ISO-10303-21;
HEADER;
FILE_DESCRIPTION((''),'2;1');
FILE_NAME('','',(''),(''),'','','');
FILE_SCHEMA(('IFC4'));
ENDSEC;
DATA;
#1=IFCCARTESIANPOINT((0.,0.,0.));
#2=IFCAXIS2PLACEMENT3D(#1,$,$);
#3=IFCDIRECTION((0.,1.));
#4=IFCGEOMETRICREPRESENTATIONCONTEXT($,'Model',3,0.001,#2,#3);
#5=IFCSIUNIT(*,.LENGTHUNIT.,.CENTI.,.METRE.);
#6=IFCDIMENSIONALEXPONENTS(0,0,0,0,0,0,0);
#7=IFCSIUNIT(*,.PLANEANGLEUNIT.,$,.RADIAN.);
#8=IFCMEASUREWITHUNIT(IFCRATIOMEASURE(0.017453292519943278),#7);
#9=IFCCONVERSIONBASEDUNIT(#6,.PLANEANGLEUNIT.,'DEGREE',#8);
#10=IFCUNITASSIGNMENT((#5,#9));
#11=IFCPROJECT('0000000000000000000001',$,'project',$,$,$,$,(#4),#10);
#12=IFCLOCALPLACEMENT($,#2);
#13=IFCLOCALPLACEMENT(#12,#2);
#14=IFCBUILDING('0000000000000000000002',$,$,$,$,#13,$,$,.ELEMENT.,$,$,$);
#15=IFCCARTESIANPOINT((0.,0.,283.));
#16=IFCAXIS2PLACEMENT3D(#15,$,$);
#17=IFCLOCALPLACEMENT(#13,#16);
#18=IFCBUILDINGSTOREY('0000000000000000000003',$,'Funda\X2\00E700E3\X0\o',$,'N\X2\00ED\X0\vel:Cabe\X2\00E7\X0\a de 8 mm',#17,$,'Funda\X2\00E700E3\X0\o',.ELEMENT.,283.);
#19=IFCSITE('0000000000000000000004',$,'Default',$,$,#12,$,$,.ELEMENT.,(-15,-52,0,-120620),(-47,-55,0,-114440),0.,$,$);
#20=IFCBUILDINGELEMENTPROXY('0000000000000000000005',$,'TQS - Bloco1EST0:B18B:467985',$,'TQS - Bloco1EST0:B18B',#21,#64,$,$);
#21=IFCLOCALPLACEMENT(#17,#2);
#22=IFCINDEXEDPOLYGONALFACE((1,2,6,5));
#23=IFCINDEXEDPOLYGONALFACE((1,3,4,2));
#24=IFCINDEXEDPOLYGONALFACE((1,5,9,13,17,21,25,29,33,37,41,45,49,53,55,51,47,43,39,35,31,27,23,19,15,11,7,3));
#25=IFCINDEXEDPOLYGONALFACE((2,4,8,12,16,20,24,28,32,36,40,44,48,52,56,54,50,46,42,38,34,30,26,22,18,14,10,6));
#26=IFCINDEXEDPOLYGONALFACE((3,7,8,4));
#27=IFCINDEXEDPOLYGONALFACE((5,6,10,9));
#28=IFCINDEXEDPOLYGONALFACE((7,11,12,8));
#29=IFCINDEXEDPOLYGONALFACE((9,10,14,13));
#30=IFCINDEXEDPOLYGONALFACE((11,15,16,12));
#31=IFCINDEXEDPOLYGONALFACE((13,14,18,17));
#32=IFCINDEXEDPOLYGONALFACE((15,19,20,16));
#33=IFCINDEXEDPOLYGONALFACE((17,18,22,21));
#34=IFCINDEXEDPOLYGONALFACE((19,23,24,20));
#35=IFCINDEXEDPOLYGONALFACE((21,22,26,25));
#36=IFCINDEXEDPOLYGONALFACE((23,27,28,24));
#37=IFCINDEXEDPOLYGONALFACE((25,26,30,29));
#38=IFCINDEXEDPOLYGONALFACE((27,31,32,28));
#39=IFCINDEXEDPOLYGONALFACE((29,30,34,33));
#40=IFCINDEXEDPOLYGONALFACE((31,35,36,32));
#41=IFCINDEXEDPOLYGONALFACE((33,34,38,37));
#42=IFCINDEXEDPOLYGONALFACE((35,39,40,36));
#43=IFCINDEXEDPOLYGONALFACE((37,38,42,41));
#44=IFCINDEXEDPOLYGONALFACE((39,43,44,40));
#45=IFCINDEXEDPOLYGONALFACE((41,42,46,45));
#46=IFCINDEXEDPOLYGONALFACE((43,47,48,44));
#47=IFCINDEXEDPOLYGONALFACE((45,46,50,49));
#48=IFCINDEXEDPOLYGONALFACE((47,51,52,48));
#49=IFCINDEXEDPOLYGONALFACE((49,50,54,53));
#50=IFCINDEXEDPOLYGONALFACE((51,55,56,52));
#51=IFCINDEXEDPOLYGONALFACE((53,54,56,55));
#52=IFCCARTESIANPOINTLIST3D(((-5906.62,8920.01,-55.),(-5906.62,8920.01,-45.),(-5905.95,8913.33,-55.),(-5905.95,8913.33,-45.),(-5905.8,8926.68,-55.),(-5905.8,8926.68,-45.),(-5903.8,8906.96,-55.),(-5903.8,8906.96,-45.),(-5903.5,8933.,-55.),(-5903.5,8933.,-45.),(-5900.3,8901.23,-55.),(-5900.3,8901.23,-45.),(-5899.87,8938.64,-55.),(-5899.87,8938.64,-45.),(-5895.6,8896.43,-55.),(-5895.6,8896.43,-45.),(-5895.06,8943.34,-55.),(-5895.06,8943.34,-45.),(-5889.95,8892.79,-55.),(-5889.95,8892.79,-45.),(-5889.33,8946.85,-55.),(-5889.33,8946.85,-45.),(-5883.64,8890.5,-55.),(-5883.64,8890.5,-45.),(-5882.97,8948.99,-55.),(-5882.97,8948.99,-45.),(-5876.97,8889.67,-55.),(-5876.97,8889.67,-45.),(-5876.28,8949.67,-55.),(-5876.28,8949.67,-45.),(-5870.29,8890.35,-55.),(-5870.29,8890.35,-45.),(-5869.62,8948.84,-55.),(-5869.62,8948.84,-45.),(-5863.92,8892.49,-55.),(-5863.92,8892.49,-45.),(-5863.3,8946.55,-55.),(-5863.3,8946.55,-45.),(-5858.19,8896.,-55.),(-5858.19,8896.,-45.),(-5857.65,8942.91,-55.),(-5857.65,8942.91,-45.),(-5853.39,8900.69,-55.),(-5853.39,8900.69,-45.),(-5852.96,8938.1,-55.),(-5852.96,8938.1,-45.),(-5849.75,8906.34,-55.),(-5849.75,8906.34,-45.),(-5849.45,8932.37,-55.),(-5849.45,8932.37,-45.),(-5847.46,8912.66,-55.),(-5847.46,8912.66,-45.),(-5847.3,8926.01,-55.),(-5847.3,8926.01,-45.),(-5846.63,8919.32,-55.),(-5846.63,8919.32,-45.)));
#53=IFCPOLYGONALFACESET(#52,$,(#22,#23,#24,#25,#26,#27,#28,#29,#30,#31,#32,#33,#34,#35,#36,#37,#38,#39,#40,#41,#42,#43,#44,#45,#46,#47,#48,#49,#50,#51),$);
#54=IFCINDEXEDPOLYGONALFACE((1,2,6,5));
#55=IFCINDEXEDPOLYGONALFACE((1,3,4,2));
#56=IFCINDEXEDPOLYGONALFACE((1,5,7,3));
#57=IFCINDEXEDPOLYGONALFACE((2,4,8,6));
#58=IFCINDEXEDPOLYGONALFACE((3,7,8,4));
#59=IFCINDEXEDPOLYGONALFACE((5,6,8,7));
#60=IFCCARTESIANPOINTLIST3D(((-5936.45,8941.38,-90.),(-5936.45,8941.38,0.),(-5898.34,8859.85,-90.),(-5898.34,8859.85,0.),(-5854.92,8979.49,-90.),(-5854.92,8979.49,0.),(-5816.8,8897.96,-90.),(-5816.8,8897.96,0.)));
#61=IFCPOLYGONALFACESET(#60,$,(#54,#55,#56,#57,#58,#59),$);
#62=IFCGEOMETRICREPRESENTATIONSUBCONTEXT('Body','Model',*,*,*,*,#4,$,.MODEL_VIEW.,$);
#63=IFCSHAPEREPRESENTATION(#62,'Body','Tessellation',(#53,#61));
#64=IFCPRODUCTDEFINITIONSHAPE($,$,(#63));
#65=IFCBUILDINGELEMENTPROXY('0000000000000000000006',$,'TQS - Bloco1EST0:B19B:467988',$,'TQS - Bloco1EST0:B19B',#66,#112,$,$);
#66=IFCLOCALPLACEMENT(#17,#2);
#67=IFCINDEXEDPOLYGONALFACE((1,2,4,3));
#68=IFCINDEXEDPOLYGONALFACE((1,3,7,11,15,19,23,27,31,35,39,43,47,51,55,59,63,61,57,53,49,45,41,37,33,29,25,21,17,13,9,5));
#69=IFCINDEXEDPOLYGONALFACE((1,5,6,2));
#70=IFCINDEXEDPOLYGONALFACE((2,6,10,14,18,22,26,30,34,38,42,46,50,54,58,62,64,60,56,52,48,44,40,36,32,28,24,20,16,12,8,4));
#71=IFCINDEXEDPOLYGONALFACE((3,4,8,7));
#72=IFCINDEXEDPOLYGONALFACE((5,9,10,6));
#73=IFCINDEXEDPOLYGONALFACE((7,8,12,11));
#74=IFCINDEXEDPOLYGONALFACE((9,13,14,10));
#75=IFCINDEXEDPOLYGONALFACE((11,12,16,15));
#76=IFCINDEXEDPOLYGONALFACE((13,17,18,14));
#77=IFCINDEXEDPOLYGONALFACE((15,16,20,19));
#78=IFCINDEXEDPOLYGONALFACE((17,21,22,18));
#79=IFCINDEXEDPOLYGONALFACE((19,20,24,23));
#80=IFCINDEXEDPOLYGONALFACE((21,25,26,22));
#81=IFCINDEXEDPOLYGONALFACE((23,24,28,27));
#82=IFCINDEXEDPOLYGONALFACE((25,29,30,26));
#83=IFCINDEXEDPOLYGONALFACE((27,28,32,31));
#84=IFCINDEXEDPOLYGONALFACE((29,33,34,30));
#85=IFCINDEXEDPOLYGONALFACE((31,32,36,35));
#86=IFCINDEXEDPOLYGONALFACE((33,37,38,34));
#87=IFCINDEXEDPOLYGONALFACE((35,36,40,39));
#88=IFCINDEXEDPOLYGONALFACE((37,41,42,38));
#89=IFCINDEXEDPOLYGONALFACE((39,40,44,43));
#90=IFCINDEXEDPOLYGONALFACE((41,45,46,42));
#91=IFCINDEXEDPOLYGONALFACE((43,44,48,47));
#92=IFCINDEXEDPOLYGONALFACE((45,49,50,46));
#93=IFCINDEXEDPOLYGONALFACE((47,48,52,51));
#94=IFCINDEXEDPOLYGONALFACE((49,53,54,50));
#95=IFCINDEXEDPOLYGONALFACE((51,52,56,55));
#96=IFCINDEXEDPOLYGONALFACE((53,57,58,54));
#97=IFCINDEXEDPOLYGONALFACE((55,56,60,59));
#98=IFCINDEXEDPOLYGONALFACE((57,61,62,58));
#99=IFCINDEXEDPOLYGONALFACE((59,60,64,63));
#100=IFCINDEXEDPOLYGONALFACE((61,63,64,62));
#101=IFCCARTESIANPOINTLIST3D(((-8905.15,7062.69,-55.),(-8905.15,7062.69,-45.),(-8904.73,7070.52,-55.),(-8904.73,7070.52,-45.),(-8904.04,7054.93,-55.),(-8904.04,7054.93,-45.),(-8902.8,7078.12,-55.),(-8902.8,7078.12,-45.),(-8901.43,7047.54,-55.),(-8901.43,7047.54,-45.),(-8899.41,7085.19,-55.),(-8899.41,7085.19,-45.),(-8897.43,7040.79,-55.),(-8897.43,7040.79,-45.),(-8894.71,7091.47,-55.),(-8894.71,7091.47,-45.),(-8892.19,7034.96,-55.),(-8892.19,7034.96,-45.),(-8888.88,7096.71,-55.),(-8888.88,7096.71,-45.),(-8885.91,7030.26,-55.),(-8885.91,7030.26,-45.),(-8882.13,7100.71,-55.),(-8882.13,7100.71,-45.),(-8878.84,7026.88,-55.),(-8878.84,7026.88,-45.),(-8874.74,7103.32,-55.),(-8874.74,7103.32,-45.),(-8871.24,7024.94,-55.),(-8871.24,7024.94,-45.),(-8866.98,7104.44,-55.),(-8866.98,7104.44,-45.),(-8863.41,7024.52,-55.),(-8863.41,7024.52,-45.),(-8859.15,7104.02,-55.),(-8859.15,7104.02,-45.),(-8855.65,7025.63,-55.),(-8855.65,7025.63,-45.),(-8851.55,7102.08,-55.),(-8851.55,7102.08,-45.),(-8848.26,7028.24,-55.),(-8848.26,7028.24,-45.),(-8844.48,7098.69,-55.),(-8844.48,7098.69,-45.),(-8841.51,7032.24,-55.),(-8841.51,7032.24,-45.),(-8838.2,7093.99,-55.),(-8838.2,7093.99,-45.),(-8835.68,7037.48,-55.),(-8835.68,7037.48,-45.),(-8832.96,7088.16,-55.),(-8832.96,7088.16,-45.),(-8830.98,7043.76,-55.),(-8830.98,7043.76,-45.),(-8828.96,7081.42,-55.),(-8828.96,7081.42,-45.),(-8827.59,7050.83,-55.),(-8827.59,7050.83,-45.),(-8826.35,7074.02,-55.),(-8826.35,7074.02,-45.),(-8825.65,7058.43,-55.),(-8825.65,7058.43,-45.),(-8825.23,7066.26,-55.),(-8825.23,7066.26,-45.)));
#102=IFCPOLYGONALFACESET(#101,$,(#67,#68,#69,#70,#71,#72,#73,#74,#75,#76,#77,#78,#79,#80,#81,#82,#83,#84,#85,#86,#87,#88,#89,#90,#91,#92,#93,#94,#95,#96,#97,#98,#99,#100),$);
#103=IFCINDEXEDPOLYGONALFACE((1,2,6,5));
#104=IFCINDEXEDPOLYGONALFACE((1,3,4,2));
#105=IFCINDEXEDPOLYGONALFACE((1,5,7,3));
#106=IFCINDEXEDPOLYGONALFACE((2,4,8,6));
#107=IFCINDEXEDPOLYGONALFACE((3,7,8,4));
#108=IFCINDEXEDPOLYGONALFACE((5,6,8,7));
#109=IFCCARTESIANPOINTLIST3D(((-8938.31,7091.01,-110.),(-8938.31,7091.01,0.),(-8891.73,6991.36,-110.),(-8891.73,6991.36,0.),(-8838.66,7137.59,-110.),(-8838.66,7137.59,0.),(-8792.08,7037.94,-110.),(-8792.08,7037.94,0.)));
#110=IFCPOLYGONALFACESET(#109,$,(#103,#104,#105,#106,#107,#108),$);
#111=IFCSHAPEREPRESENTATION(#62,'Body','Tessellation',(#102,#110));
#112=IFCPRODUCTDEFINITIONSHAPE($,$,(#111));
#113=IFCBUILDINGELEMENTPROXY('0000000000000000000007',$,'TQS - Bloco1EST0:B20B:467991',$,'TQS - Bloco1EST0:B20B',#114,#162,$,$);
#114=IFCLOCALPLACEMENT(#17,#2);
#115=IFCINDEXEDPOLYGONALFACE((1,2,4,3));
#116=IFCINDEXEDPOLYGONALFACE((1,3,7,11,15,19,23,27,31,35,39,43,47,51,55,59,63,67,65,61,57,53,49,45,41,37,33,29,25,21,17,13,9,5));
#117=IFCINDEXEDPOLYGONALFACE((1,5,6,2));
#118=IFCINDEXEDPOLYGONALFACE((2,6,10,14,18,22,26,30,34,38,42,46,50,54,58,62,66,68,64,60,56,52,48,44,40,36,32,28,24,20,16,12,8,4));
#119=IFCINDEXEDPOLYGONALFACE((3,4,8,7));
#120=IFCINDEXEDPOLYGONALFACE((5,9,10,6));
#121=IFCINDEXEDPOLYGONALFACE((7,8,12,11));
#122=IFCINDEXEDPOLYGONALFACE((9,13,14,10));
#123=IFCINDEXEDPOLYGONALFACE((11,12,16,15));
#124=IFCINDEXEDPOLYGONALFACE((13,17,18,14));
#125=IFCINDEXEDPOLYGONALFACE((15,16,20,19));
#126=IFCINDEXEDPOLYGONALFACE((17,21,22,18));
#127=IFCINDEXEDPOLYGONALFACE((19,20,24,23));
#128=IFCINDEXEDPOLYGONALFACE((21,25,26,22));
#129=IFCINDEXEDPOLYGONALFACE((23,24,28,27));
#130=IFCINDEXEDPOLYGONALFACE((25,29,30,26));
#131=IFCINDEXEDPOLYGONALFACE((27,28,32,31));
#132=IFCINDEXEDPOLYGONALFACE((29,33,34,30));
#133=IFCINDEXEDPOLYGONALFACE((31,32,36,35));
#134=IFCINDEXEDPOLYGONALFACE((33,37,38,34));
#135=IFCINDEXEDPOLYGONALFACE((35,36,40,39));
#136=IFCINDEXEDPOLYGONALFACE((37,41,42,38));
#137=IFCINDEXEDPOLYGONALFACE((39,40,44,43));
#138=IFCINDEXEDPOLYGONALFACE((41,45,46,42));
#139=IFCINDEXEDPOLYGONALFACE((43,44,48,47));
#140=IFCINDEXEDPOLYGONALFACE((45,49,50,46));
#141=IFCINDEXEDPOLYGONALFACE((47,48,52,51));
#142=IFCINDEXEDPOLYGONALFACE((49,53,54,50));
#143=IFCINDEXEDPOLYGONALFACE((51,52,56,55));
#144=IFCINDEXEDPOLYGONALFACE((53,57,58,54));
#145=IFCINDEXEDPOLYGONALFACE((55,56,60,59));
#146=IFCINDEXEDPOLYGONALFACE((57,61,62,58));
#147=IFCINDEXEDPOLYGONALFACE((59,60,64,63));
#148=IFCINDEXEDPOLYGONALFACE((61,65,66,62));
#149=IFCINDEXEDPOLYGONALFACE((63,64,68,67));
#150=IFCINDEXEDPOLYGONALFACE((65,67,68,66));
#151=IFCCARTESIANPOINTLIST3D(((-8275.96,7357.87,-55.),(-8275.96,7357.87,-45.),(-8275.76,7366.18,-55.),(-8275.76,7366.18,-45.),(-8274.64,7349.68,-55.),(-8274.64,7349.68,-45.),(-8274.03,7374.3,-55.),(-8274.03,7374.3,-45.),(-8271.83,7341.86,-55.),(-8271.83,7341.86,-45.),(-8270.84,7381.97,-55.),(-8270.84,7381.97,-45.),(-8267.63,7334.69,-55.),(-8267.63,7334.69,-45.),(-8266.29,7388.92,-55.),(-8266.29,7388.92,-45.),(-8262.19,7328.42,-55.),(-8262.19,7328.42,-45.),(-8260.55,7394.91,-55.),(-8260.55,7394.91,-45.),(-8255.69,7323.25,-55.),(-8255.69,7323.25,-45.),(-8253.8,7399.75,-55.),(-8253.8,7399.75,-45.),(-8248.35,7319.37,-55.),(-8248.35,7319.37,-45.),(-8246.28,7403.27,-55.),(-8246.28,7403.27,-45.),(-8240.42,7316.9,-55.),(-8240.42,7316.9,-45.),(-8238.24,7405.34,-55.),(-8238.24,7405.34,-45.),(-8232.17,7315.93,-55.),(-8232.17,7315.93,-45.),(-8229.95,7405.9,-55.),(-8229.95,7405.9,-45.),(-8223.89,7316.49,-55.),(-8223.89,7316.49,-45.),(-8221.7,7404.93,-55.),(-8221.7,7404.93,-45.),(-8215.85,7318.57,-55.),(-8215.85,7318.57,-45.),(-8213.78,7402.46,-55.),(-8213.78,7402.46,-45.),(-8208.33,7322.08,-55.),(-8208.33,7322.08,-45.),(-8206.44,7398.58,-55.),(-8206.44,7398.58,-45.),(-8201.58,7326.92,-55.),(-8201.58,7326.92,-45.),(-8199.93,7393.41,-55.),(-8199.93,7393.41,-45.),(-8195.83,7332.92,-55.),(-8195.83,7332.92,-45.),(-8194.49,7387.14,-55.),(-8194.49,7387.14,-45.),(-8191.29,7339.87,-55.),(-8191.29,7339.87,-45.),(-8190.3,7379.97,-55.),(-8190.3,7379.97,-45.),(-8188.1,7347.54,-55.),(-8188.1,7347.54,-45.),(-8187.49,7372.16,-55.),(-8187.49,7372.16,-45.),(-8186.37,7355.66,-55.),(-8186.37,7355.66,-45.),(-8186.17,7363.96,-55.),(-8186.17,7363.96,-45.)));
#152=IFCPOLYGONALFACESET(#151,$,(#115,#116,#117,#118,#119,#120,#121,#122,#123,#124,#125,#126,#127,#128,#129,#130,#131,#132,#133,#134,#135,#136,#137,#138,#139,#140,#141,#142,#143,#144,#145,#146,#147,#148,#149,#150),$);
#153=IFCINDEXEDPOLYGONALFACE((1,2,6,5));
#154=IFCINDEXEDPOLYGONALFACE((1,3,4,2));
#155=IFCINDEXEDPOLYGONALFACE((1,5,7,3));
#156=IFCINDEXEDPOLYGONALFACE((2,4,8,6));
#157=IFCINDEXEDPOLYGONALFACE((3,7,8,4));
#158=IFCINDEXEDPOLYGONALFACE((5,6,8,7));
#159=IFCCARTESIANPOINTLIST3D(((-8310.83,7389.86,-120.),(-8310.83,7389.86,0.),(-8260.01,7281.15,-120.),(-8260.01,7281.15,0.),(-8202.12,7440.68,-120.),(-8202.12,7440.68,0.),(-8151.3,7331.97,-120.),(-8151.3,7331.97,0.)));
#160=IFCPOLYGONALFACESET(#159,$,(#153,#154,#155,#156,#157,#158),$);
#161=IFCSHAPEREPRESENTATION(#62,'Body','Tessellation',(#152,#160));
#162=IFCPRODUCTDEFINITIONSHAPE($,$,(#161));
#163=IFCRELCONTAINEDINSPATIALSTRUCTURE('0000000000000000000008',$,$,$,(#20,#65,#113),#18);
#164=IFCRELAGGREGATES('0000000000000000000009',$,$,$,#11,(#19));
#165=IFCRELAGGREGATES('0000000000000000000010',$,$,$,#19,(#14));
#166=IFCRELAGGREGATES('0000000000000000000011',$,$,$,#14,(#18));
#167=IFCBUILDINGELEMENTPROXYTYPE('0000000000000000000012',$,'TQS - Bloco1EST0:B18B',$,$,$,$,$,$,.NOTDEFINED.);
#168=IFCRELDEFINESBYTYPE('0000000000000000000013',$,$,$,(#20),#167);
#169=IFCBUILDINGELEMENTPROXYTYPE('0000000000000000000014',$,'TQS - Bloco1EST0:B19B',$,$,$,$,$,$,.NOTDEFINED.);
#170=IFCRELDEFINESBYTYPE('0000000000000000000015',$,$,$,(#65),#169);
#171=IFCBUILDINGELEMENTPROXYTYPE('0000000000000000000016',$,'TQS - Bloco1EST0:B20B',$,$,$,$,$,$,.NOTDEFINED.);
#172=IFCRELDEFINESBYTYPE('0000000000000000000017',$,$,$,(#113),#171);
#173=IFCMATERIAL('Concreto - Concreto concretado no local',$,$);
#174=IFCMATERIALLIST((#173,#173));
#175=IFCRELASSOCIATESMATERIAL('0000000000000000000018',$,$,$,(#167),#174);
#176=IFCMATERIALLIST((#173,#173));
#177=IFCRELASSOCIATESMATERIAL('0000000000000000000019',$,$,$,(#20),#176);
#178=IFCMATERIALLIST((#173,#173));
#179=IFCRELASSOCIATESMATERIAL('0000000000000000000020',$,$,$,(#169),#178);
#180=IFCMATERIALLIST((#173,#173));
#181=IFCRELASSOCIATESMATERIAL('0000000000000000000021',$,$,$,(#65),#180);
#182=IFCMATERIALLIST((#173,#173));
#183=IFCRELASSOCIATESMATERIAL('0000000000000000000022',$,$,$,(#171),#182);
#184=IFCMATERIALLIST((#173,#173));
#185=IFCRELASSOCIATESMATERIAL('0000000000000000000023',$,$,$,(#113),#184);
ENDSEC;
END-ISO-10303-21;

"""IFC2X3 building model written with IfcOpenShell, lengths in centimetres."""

from ifc_helpers import new_model, entity, si_unit, converted_unit, direction, frame, frame_2d, origin, origin_2d_with_axis, place, context, subcontext, project, spatial, rectangle, circle, extrude, source, transform, mapped, material, material_list, type_object, type_shapes, element, save


model = new_model("IFC2X3")

# Units and contexts
model_context = context("Model", 3, precision=0.001, world=origin(), true_north=direction((0.0, 1.0)))
body_context = subcontext(model_context, "Body", "Model", "MODEL_VIEW")
ifc_project = project(units=[si_unit("LENGTHUNIT", "METRE", prefix="CENTI"), converted_unit("PLANEANGLEUNIT", "DEGREE", entity("IfcRatioMeasure", 0.017453292519943278), si_unit("PLANEANGLEUNIT", "RADIAN"), dimensions=[0, 0, 0, 0, 0, 0, 0])], contexts=[model_context])

# Site, building, storey
site_placement = place(None, origin())
site = spatial("IfcSite", under=ifc_project, at=site_placement, Name="Default", CompositionType="ELEMENT", RefLatitude=(-15, -52, 0, -120620), RefLongitude=(-47, -55, 0, -114440), RefElevation=0.0)
building_placement = place(site_placement, origin())
building = spatial("IfcBuilding", under=site, at=building_placement, CompositionType="ELEMENT")
storey_placement = place(building_placement, frame((0.0, 0.0, 283.0)))
storey = spatial("IfcBuildingStorey", under=building, at=storey_placement, Name="Fundação", ObjectType="Nível:Cabeça de 8 mm", LongName="Fundação", CompositionType="ELEMENT", Elevation=283.0)

# Building element proxies
ifc_material_1 = material(Name="Concreto - Concreto concretado no local")
ifc_material_list_1 = material_list([ifc_material_1, ifc_material_1])
ifc_material_list_2 = material_list([ifc_material_1, ifc_material_1])
building_element_proxy_type_1 = type_object("IfcBuildingElementProxyType", Name="TQS - Bloco1EST0:B18B", PredefinedType="NOTDEFINED", material=ifc_material_list_2)
shared_shape_1 = source(origin(), body_context, "Body", "SweptSolid", [
    extrude(circle(Radius=30.0, at=frame_2d((0.0, 0.0), x_axis=(1.0, 0.0))), frame((0.0, 0.0, -55.0)), (0.0, 0.0, 1.0), 10.0),
    extrude(rectangle(XDim=90.0, YDim=90.0, at=origin_2d_with_axis()), frame((0.0, 0.0, -90.0), z_axis=(0.0, 0.0, 1.0), x_axis=(-1.0, 0.0, 0.0)), (0.0, 0.0, 1.0), 90.0),
])
type_shapes(building_element_proxy_type_1, [shared_shape_1])
proxy_1_placement = place(storey_placement, frame((-5876.63, 8919.67, 0.0), z_axis=(0.0, 0.0, 1.0), x_axis=(0.905902, 0.423488, 0.0)))
element("IfcBuildingElementProxy", 1, at=proxy_1_placement, inside=storey, type_object=building_element_proxy_type_1, material=ifc_material_list_1, Name="TQS - Bloco1EST0:B18B:467985", ObjectType="TQS - Bloco1EST0:B18B", context=body_context, shape_type="MappedRepresentation", body=[
    mapped(shared_shape_1, transform((0.0, 0.0, 0.0), scale=1.0)),
])
ifc_material_list_3 = material_list([ifc_material_1, ifc_material_1])
ifc_material_list_4 = material_list([ifc_material_1, ifc_material_1])
building_element_proxy_type_2 = type_object("IfcBuildingElementProxyType", Name="TQS - Bloco1EST0:B19B", PredefinedType="NOTDEFINED", material=ifc_material_list_4)
shared_shape_2 = source(origin(), body_context, "Body", "SweptSolid", [
    extrude(circle(Radius=40.0, at=frame_2d((0.0, 0.0), x_axis=(1.0, 0.0))), frame((0.0, 0.0, -55.0)), (0.0, 0.0, 1.0), 10.0),
    extrude(rectangle(XDim=110.0, YDim=110.0, at=origin_2d_with_axis()), frame((0.0, 0.0, -110.0), z_axis=(0.0, 0.0, 1.0), x_axis=(-1.0, 0.0, 0.0)), (0.0, 0.0, 1.0), 110.0),
])
type_shapes(building_element_proxy_type_2, [shared_shape_2])
proxy_2_placement = place(storey_placement, frame((-8865.19, 7064.48, 0.0), z_axis=(0.0, 0.0, 1.0), x_axis=(0.905902, 0.423488, 0.0)))
element("IfcBuildingElementProxy", 2, at=proxy_2_placement, inside=storey, type_object=building_element_proxy_type_2, material=ifc_material_list_3, Name="TQS - Bloco1EST0:B19B:467988", ObjectType="TQS - Bloco1EST0:B19B", context=body_context, shape_type="MappedRepresentation", body=[
    mapped(shared_shape_2, transform((0.0, 0.0, 0.0), scale=1.0)),
])
ifc_material_list_5 = material_list([ifc_material_1, ifc_material_1])
ifc_material_list_6 = material_list([ifc_material_1, ifc_material_1])
building_element_proxy_type_3 = type_object("IfcBuildingElementProxyType", Name="TQS - Bloco1EST0:B20B", PredefinedType="NOTDEFINED", material=ifc_material_list_6)
shared_shape_3 = source(origin(), body_context, "Body", "SweptSolid", [
    extrude(circle(Radius=45.0, at=frame_2d((0.0, 0.0), x_axis=(1.0, 0.0))), frame((0.0, 0.0, -55.0)), (0.0, 0.0, 1.0), 10.0),
    extrude(rectangle(XDim=120.0, YDim=120.0, at=origin_2d_with_axis()), frame((0.0, 0.0, -120.0), z_axis=(0.0, 0.0, 1.0), x_axis=(-1.0, 0.0, 0.0)), (0.0, 0.0, 1.0), 120.0),
])
type_shapes(building_element_proxy_type_3, [shared_shape_3])
proxy_3_placement = place(storey_placement, frame((-8231.06, 7360.92, 0.0), z_axis=(0.0, 0.0, 1.0), x_axis=(0.905902, 0.423488, 0.0)))
element("IfcBuildingElementProxy", 3, at=proxy_3_placement, inside=storey, type_object=building_element_proxy_type_3, material=ifc_material_list_5, Name="TQS - Bloco1EST0:B20B:467991", ObjectType="TQS - Bloco1EST0:B20B", context=body_context, shape_type="MappedRepresentation", body=[
    mapped(shared_shape_3, transform((0.0, 0.0, 0.0), scale=1.0)),
])

save(model, "model.ifc")
